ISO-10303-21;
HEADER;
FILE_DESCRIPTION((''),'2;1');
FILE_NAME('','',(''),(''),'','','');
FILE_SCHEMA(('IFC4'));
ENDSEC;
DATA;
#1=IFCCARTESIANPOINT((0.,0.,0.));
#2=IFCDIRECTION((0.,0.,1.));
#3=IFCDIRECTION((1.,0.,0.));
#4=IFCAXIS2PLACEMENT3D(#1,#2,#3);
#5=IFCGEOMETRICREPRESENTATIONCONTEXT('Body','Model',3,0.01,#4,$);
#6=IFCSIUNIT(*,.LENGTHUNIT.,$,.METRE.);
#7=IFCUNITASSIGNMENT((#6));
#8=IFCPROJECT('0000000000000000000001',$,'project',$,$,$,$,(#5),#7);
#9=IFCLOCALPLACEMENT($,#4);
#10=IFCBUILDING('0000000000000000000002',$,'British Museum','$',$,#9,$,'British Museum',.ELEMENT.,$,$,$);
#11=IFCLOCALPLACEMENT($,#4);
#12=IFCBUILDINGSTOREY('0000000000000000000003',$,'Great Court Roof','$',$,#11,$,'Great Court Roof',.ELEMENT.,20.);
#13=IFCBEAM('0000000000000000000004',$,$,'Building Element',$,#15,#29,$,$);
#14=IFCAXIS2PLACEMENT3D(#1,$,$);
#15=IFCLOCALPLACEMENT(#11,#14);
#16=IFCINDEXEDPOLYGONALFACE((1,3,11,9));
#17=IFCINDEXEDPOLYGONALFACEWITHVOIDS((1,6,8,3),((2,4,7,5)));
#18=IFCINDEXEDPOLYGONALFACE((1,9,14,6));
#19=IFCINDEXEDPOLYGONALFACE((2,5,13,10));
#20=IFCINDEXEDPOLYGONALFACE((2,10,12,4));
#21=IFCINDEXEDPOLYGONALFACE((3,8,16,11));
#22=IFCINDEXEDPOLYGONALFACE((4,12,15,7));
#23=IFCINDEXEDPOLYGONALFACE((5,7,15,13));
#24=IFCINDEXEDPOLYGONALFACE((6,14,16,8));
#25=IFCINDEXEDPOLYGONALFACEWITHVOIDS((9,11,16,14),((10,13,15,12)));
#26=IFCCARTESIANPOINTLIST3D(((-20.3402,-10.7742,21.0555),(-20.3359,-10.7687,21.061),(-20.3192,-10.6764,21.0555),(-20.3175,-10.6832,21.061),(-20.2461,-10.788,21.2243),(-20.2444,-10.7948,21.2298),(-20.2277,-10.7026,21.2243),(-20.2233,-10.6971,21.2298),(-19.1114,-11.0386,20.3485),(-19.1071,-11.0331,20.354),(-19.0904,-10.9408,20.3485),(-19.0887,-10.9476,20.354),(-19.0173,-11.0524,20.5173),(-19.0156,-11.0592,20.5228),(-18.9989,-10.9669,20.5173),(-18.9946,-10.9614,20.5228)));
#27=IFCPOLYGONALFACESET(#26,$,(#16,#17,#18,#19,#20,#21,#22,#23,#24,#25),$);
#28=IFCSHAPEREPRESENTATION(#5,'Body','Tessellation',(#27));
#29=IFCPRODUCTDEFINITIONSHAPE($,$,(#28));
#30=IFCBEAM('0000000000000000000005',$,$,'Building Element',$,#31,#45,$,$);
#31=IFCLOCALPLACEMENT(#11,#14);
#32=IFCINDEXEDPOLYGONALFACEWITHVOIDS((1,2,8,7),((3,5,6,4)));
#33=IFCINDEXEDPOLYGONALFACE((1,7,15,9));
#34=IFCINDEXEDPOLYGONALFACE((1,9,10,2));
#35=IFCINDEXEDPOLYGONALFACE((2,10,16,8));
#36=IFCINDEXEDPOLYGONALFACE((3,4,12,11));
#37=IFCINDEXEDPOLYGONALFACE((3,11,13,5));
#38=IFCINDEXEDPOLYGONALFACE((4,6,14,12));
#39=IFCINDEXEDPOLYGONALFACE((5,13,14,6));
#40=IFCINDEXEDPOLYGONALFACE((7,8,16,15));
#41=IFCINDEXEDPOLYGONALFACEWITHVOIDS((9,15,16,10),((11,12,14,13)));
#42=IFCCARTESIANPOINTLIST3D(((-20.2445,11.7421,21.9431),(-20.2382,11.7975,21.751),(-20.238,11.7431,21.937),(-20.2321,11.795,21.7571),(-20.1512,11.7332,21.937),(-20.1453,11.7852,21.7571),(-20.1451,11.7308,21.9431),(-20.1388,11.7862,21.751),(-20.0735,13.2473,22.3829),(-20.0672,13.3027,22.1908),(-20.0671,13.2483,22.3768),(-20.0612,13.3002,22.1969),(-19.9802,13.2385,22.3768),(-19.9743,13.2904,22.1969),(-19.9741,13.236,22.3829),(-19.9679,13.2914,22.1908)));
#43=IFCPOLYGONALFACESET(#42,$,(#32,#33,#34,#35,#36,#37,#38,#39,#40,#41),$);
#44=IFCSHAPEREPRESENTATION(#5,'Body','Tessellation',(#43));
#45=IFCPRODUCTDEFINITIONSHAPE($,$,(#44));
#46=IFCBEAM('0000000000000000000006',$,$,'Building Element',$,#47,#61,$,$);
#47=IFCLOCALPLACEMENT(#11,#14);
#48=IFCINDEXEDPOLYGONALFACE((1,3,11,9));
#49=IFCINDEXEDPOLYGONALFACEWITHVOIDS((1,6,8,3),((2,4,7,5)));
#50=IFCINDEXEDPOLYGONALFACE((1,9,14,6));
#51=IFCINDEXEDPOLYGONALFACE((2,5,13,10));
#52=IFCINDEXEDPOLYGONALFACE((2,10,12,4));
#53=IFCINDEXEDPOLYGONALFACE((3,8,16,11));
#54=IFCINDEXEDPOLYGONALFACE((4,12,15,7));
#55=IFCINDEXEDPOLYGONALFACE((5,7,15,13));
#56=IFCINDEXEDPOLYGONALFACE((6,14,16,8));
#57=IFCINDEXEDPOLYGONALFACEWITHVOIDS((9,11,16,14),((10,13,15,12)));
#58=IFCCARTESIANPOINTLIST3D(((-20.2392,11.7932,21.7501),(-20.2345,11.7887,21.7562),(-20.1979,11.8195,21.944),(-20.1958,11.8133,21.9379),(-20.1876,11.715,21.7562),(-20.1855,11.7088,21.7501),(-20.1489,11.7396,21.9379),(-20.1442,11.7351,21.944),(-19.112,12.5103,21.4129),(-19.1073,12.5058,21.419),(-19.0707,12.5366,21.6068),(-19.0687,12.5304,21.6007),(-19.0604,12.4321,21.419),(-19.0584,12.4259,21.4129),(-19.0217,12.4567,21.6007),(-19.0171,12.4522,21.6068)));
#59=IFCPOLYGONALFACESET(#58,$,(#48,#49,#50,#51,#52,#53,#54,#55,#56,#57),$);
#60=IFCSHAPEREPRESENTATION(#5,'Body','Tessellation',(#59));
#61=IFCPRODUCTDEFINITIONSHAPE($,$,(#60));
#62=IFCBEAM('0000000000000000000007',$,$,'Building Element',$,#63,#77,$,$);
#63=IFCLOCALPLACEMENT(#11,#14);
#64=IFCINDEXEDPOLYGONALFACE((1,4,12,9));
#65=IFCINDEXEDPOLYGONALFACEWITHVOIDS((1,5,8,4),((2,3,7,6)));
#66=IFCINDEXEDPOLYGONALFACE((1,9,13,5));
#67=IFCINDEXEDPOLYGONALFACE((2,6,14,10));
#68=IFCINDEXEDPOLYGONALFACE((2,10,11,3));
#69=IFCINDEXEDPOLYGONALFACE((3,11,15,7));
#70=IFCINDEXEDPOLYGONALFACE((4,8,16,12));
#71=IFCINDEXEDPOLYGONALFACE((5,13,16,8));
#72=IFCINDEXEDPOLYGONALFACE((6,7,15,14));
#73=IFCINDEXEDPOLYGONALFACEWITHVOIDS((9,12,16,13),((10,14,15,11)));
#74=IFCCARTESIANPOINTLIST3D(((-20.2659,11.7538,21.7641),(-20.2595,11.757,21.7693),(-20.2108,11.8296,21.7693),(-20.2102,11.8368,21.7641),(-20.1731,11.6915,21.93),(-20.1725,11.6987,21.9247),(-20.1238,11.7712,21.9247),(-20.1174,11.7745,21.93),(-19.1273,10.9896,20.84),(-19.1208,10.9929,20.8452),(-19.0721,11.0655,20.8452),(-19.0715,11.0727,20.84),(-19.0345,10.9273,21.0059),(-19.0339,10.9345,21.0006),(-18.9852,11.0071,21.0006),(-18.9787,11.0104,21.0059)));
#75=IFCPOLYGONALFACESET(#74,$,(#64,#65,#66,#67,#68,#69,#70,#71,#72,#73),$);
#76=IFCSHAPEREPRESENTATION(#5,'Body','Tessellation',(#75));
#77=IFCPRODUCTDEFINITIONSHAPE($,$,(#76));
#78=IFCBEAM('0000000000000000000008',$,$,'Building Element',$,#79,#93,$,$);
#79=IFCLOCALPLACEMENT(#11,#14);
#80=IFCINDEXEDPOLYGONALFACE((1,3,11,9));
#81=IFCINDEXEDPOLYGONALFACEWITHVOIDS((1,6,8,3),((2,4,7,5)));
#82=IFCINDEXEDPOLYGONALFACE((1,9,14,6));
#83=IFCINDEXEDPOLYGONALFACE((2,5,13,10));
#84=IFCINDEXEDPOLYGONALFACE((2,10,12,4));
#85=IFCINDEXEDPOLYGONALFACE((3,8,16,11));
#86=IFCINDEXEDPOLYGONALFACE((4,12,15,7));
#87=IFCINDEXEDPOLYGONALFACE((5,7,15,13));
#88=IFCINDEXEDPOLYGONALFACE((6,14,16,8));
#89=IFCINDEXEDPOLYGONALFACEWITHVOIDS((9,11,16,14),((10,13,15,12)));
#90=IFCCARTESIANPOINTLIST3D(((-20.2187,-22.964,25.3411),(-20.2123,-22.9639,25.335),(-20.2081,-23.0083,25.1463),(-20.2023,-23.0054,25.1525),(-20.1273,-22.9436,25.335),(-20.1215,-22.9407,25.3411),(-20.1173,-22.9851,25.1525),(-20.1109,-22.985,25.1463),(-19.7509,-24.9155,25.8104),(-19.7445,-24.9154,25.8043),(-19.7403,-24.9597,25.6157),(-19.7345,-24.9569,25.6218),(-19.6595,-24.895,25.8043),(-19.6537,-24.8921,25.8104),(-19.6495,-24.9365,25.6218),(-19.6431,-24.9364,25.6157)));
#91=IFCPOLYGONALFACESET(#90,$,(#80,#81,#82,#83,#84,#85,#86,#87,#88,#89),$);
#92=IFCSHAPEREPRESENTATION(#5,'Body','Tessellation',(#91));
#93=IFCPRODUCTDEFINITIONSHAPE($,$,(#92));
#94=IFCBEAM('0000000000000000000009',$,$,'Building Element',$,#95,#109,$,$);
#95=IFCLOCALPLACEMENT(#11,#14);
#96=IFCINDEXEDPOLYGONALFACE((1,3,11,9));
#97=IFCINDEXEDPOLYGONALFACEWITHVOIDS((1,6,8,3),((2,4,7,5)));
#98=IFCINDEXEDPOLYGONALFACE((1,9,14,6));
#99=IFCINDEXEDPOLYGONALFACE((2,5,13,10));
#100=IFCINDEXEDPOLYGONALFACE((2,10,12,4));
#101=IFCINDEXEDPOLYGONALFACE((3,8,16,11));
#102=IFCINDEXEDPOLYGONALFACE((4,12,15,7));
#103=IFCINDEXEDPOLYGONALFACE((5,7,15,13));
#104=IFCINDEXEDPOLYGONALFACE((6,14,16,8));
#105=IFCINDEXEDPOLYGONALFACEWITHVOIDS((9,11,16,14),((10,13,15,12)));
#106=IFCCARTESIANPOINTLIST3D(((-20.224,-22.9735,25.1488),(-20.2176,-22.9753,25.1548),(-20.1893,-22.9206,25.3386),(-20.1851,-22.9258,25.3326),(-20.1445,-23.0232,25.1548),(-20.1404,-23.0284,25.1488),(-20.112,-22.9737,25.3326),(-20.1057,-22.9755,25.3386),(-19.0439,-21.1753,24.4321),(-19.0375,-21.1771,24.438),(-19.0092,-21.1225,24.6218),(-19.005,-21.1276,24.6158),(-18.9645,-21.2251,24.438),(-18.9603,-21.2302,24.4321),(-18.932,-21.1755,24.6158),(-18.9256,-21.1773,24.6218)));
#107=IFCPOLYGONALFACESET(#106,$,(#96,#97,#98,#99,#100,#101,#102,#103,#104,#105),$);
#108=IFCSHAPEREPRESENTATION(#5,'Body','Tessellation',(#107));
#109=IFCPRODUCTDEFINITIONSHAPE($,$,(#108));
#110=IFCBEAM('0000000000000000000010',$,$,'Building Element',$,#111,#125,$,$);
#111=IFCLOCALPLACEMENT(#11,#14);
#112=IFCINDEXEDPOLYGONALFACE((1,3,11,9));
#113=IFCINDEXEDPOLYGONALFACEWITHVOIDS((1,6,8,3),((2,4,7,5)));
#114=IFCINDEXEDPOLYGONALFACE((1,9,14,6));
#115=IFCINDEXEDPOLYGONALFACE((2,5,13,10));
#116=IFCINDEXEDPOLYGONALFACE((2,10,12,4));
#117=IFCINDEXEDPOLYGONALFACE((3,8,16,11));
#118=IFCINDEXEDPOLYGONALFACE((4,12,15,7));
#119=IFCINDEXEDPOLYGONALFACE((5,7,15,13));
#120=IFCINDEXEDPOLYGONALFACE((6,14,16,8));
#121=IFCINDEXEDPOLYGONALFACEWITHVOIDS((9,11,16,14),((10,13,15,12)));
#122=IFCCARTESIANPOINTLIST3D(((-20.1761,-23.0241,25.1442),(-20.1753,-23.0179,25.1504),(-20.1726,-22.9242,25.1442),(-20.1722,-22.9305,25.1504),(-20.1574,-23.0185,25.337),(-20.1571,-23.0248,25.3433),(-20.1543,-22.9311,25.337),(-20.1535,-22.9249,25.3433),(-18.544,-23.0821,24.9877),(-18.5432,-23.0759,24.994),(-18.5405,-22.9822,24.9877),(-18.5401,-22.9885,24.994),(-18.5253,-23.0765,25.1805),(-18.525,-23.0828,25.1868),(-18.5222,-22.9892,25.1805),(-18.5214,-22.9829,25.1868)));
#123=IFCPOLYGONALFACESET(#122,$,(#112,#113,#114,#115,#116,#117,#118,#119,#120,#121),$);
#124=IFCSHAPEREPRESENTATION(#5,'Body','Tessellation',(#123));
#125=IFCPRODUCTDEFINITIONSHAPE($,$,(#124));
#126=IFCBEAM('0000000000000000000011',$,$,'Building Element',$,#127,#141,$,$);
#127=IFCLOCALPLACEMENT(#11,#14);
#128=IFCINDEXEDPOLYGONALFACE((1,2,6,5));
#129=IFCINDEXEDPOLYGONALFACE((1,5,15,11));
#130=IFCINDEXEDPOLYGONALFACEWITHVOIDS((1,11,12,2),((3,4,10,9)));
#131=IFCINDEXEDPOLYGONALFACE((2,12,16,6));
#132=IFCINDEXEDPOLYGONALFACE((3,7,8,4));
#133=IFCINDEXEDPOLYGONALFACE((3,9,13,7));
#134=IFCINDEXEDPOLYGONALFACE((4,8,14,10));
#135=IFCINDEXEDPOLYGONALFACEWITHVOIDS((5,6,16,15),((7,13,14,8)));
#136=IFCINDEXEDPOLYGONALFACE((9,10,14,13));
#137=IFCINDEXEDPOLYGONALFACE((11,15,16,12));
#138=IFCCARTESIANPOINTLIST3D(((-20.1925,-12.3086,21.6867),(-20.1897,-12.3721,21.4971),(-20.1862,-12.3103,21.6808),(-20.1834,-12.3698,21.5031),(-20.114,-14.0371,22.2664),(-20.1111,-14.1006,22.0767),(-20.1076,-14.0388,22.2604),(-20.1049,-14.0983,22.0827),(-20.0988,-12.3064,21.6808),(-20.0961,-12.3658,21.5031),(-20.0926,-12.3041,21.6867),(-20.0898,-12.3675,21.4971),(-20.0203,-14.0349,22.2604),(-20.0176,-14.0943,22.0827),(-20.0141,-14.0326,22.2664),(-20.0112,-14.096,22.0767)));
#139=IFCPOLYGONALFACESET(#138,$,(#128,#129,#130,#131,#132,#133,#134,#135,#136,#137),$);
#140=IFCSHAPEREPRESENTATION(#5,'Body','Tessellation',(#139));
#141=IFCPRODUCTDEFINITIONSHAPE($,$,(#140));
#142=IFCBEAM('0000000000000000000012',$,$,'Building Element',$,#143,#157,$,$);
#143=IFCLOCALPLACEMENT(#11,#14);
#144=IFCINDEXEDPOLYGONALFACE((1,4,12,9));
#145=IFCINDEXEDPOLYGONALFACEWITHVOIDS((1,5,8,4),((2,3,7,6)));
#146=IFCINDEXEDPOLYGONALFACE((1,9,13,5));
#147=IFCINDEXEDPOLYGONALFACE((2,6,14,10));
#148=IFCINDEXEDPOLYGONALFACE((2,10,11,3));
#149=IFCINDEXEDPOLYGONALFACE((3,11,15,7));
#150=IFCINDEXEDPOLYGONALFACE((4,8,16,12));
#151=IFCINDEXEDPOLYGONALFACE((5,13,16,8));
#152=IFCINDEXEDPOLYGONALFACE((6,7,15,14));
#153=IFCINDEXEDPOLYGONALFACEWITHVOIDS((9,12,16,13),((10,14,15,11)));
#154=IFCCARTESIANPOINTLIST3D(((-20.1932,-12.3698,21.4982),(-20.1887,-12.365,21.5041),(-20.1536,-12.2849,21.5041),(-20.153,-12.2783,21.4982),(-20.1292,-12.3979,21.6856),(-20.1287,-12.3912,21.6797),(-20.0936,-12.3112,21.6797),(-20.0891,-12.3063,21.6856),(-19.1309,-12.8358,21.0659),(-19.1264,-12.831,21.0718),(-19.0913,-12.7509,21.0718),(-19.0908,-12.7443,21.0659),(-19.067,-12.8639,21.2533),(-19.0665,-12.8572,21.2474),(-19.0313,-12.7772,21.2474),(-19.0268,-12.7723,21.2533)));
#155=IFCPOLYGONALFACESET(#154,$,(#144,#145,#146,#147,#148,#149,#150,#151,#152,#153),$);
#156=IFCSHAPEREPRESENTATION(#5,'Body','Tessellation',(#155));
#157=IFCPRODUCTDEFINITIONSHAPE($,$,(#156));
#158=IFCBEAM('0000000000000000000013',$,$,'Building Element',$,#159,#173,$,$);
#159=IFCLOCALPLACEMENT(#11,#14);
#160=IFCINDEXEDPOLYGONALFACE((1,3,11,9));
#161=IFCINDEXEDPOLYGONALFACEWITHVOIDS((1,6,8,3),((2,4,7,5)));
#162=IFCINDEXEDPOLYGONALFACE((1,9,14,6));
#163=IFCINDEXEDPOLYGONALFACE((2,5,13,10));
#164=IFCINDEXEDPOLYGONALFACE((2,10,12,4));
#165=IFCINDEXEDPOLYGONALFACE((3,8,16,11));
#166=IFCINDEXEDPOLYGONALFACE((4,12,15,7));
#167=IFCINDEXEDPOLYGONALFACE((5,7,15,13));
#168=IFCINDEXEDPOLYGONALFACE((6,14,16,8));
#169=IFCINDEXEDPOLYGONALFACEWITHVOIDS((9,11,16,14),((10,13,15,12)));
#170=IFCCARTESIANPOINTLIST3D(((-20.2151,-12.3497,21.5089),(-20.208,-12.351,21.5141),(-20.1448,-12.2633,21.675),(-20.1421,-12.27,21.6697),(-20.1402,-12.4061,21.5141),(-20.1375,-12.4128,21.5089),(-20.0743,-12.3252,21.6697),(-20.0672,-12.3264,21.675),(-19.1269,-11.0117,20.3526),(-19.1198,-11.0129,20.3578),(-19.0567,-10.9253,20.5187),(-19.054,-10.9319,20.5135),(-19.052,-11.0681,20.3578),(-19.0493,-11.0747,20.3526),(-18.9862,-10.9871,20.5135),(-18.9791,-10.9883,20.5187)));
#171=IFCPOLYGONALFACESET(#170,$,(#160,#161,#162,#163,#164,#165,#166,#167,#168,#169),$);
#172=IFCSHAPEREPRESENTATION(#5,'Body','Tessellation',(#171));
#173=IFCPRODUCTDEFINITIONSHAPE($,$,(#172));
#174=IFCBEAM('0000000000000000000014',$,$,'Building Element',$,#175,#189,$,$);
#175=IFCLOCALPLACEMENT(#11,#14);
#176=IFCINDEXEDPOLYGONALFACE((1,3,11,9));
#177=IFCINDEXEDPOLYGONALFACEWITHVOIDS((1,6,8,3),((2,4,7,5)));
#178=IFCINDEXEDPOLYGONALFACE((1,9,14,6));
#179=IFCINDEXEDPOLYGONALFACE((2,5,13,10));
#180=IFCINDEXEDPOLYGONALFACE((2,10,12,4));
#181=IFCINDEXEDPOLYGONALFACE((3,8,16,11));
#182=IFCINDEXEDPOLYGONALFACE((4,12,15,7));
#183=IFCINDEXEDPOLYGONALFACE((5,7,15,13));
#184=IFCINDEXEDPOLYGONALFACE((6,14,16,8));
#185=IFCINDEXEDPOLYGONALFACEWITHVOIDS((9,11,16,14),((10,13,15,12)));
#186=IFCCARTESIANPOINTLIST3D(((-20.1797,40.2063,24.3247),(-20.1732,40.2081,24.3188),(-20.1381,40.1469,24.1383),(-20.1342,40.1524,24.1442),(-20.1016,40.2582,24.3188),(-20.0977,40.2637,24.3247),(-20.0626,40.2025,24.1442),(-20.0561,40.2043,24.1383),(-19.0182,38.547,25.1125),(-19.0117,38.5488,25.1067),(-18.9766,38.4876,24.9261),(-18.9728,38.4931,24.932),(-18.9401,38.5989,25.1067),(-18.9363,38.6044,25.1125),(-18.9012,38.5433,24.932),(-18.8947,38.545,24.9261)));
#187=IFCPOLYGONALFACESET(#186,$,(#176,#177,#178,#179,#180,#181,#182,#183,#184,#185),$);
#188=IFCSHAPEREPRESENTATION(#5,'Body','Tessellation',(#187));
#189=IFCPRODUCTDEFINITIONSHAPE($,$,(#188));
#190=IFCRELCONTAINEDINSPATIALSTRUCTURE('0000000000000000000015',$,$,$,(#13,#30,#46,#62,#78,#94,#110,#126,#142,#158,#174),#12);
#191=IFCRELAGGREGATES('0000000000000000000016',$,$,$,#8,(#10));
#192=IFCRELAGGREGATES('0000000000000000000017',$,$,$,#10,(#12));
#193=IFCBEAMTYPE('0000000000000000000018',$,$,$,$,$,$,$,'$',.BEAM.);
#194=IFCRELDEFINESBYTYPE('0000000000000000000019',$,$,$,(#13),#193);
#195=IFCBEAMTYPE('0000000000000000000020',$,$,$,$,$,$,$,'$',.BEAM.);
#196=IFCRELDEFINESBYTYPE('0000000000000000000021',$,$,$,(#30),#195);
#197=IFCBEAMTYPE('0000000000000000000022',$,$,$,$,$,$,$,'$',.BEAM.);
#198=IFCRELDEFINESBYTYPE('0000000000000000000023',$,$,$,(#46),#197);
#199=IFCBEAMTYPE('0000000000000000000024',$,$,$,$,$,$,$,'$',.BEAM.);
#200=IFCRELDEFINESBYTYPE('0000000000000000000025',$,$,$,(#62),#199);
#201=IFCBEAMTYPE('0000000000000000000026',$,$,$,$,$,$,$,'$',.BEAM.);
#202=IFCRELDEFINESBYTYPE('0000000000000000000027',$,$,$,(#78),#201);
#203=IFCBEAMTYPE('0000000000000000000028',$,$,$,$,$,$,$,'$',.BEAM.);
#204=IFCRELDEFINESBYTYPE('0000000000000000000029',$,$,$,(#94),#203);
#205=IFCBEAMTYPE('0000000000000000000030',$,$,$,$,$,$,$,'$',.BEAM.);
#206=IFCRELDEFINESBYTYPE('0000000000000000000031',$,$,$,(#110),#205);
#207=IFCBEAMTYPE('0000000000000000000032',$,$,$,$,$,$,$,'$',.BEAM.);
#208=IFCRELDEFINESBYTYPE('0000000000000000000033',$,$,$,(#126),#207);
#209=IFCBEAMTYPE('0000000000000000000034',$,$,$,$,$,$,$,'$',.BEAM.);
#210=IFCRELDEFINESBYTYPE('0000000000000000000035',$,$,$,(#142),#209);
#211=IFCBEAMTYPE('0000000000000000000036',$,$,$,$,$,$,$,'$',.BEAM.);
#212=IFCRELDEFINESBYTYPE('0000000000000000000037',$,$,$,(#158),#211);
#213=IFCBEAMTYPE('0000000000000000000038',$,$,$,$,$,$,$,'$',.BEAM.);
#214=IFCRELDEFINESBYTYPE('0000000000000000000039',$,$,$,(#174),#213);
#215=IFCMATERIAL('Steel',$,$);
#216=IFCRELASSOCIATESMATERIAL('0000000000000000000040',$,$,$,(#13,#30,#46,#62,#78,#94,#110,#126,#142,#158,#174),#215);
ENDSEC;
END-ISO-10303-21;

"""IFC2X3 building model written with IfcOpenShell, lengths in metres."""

from ifc_helpers import new_model, si_unit, frame, origin_with_axes, origin_2d, place, context, project, spatial, hollow_rectangle, extrude, material, type_object, element, save


model = new_model("IFC2X3")

# Units and contexts
model_context = context("Model", 3, precision=0.01, world=origin_with_axes(), identifier="Body")
ifc_project = project(units=[si_unit("LENGTHUNIT", "METRE")], contexts=[model_context])

# Building, storey
building_placement = place(None, origin_with_axes())
building = spatial("IfcBuilding", under=ifc_project, at=building_placement, Name="British Museum", Description="$", LongName="British Museum", CompositionType="ELEMENT")
storey_placement = place(None, origin_with_axes())
storey = spatial("IfcBuildingStorey", under=building, at=storey_placement, Name="Great Court Roof", Description="$", LongName="Great Court Roof", CompositionType="ELEMENT", Elevation=20.0)

# Beams
ifc_material = material(Name="Steel")
beam_type_1 = type_object("IfcBeamType", ElementType="$", PredefinedType="BEAM")
beam_1_placement = place(None, origin_with_axes())
element("IfcBeam", 1, at=beam_1_placement, inside=storey, type_object=beam_type_1, material=ifc_material, Description="Building Element", context=model_context, shape_type="SweptSolid", body=[
    extrude(hollow_rectangle(XDim=0.1, YDim=0.2, WallThickness=0.0063, InnerFilletRadius=-0.0063, OuterFilletRadius=0.0, at=origin_2d()), frame((-20.2818, -10.7356, 21.1427), z_axis=(0.852077, -0.183325, -0.490263), x_axis=(0.210338, 0.977629, 0.0)), (0.0, 0.0, 1.0), 1.4421),
])
beam_type_2 = type_object("IfcBeamType", ElementType="$", PredefinedType="BEAM")
beam_2_placement = place(None, origin_with_axes())
element("IfcBeam", 2, at=beam_2_placement, inside=storey, type_object=beam_type_2, material=ifc_material, Description="Building Element", context=model_context, shape_type="SweptSolid", body=[
    extrude(hollow_rectangle(XDim=0.1, YDim=0.2, WallThickness=0.0063, InnerFilletRadius=-0.0063, OuterFilletRadius=0.0, at=origin_2d()), frame((-20.1917, 11.7641, 21.847), z_axis=(0.108391, 0.954208, 0.278816), x_axis=(-0.99361, 0.112867, 0.0)), (0.0, 0.0, 1.0), 1.5774),
])
beam_type_3 = type_object("IfcBeamType", ElementType="$", PredefinedType="BEAM")
beam_3_placement = place(None, origin_with_axes())
element("IfcBeam", 3, at=beam_3_placement, inside=storey, type_object=beam_type_3, material=ifc_material, Description="Building Element", context=model_context, shape_type="SweptSolid", body=[
    extrude(hollow_rectangle(XDim=0.1, YDim=0.2, WallThickness=0.0063, InnerFilletRadius=-0.0063, OuterFilletRadius=0.0, at=origin_2d()), frame((-20.1917, 11.7641, 21.847), z_axis=(0.818056, 0.520466, -0.244746), x_axis=(-0.536791, 0.843715, 0.0)), (0.0, 0.0, 1.0), 1.3778),
])
beam_type_4 = type_object("IfcBeamType", ElementType="$", PredefinedType="BEAM")
beam_4_placement = place(None, origin_with_axes())
element("IfcBeam", 4, at=beam_4_placement, inside=storey, type_object=beam_type_4, material=ifc_material, Description="Building Element", context=model_context, shape_type="SweptSolid", body=[
    extrude(hollow_rectangle(XDim=0.1, YDim=0.2, WallThickness=0.0063, InnerFilletRadius=-0.0063, OuterFilletRadius=0.0, at=origin_2d()), frame((-20.1917, 11.7641, 21.847), z_axis=(0.688593, -0.462103, -0.558838), x_axis=(0.557237, 0.830354, 0.0)), (0.0, 0.0, 1.0), 1.6536),
])
beam_type_5 = type_object("IfcBeamType", ElementType="$", PredefinedType="BEAM")
beam_5_placement = place(None, origin_with_axes())
element("IfcBeam", 5, at=beam_5_placement, inside=storey, type_object=beam_type_5, material=ifc_material, Description="Building Element", context=model_context, shape_type="SweptSolid", body=[
    extrude(hollow_rectangle(XDim=0.1, YDim=0.2, WallThickness=0.0063, InnerFilletRadius=-0.0063, OuterFilletRadius=0.0, at=origin_2d()), frame((-20.1648, -22.9745, 25.2437), z_axis=(0.226996, -0.946895, 0.227735), x_axis=(0.972447, 0.233122, 0.0)), (0.0, 0.0, 1.0), 2.0609),
])
beam_type_6 = type_object("IfcBeamType", ElementType="$", PredefinedType="BEAM")
beam_6_placement = place(None, origin_with_axes())
element("IfcBeam", 6, at=beam_6_placement, inside=storey, type_object=beam_type_6, material=ifc_material, Description="Building Element", context=model_context, shape_type="SweptSolid", body=[
    extrude(hollow_rectangle(XDim=0.1, YDim=0.2, WallThickness=0.0063, InnerFilletRadius=-0.0063, OuterFilletRadius=0.0, at=origin_2d()), frame((-20.1648, -22.9745, 25.2437), z_axis=(0.52051, 0.793163, -0.316169), x_axis=(-0.83605, 0.548654, 0.0)), (0.0, 0.0, 1.0), 2.2671),
])
beam_type_7 = type_object("IfcBeamType", ElementType="$", PredefinedType="BEAM")
beam_7_placement = place(None, origin_with_axes())
element("IfcBeam", 7, at=beam_7_placement, inside=storey, type_object=beam_type_7, material=ifc_material, Description="Building Element", context=model_context, shape_type="SweptSolid", body=[
    extrude(hollow_rectangle(XDim=0.1, YDim=0.2, WallThickness=0.0063, InnerFilletRadius=-0.0063, OuterFilletRadius=0.0, at=origin_2d()), frame((-20.1648, -22.9745, 25.2437), z_axis=(0.994812, -0.035363, -0.095383), x_axis=(0.035525, 0.999369, 0.0)), (0.0, 0.0, 1.0), 1.6406),
])
beam_type_8 = type_object("IfcBeamType", ElementType="$", PredefinedType="BEAM")
beam_8_placement = place(None, origin_with_axes())
element("IfcBeam", 8, at=beam_8_placement, inside=storey, type_object=beam_type_8, material=ifc_material, Description="Building Element", context=model_context, shape_type="SweptSolid", body=[
    extrude(hollow_rectangle(XDim=0.1, YDim=0.2, WallThickness=0.0063, InnerFilletRadius=-0.0063, OuterFilletRadius=0.0, at=origin_2d()), frame((-20.1411, -12.3381, 21.5919), z_axis=(0.043049, -0.947233, 0.317642), x_axis=(0.998969, 0.0454, 0.0)), (0.0, 0.0, 1.0), 1.8248),
])
beam_type_9 = type_object("IfcBeamType", ElementType="$", PredefinedType="BEAM")
beam_9_placement = place(None, origin_with_axes())
element("IfcBeam", 9, at=beam_9_placement, inside=storey, type_object=beam_type_9, material=ifc_material, Description="Building Element", context=model_context, shape_type="SweptSolid", body=[
    extrude(hollow_rectangle(XDim=0.1, YDim=0.2, WallThickness=0.0063, InnerFilletRadius=-0.0063, OuterFilletRadius=0.0, at=origin_2d()), frame((-20.1411, -12.3381, 21.5919), z_axis=(0.858097, -0.376432, -0.34924), x_axis=(0.401728, 0.915759, 0.0)), (0.0, 0.0, 1.0), 1.2379),
])
beam_type_10 = type_object("IfcBeamType", ElementType="$", PredefinedType="BEAM")
beam_10_placement = place(None, origin_with_axes())
element("IfcBeam", 10, at=beam_10_placement, inside=storey, type_object=beam_type_10, material=ifc_material, Description="Building Element", context=model_context, shape_type="SweptSolid", body=[
    extrude(hollow_rectangle(XDim=0.1, YDim=0.2, WallThickness=0.0063, InnerFilletRadius=-0.0063, OuterFilletRadius=0.0, at=origin_2d()), frame((-20.1411, -12.3381, 21.5919), z_axis=(0.524054, 0.644426, -0.55685), x_axis=(-0.775844, 0.630925, 0.0)), (0.0, 0.0, 1.0), 2.0764),
])
beam_type_11 = type_object("IfcBeamType", ElementType="$", PredefinedType="BEAM")
beam_11_placement = place(None, origin_with_axes())
element("IfcBeam", 11, at=beam_11_placement, inside=storey, type_object=beam_type_11, material=ifc_material, Description="Building Element", context=model_context, shape_type="SweptSolid", body=[
    extrude(hollow_rectangle(XDim=0.1, YDim=0.2, WallThickness=0.0063, InnerFilletRadius=-0.0063, OuterFilletRadius=0.0, at=origin_2d()), frame((-20.1179, 40.2053, 24.2315), z_axis=(0.534439, -0.76351, 0.36253), x_axis=(0.819241, 0.57345, 0.0)), (0.0, 0.0, 1.0), 2.1732),
])

save(model, "model.ifc")
